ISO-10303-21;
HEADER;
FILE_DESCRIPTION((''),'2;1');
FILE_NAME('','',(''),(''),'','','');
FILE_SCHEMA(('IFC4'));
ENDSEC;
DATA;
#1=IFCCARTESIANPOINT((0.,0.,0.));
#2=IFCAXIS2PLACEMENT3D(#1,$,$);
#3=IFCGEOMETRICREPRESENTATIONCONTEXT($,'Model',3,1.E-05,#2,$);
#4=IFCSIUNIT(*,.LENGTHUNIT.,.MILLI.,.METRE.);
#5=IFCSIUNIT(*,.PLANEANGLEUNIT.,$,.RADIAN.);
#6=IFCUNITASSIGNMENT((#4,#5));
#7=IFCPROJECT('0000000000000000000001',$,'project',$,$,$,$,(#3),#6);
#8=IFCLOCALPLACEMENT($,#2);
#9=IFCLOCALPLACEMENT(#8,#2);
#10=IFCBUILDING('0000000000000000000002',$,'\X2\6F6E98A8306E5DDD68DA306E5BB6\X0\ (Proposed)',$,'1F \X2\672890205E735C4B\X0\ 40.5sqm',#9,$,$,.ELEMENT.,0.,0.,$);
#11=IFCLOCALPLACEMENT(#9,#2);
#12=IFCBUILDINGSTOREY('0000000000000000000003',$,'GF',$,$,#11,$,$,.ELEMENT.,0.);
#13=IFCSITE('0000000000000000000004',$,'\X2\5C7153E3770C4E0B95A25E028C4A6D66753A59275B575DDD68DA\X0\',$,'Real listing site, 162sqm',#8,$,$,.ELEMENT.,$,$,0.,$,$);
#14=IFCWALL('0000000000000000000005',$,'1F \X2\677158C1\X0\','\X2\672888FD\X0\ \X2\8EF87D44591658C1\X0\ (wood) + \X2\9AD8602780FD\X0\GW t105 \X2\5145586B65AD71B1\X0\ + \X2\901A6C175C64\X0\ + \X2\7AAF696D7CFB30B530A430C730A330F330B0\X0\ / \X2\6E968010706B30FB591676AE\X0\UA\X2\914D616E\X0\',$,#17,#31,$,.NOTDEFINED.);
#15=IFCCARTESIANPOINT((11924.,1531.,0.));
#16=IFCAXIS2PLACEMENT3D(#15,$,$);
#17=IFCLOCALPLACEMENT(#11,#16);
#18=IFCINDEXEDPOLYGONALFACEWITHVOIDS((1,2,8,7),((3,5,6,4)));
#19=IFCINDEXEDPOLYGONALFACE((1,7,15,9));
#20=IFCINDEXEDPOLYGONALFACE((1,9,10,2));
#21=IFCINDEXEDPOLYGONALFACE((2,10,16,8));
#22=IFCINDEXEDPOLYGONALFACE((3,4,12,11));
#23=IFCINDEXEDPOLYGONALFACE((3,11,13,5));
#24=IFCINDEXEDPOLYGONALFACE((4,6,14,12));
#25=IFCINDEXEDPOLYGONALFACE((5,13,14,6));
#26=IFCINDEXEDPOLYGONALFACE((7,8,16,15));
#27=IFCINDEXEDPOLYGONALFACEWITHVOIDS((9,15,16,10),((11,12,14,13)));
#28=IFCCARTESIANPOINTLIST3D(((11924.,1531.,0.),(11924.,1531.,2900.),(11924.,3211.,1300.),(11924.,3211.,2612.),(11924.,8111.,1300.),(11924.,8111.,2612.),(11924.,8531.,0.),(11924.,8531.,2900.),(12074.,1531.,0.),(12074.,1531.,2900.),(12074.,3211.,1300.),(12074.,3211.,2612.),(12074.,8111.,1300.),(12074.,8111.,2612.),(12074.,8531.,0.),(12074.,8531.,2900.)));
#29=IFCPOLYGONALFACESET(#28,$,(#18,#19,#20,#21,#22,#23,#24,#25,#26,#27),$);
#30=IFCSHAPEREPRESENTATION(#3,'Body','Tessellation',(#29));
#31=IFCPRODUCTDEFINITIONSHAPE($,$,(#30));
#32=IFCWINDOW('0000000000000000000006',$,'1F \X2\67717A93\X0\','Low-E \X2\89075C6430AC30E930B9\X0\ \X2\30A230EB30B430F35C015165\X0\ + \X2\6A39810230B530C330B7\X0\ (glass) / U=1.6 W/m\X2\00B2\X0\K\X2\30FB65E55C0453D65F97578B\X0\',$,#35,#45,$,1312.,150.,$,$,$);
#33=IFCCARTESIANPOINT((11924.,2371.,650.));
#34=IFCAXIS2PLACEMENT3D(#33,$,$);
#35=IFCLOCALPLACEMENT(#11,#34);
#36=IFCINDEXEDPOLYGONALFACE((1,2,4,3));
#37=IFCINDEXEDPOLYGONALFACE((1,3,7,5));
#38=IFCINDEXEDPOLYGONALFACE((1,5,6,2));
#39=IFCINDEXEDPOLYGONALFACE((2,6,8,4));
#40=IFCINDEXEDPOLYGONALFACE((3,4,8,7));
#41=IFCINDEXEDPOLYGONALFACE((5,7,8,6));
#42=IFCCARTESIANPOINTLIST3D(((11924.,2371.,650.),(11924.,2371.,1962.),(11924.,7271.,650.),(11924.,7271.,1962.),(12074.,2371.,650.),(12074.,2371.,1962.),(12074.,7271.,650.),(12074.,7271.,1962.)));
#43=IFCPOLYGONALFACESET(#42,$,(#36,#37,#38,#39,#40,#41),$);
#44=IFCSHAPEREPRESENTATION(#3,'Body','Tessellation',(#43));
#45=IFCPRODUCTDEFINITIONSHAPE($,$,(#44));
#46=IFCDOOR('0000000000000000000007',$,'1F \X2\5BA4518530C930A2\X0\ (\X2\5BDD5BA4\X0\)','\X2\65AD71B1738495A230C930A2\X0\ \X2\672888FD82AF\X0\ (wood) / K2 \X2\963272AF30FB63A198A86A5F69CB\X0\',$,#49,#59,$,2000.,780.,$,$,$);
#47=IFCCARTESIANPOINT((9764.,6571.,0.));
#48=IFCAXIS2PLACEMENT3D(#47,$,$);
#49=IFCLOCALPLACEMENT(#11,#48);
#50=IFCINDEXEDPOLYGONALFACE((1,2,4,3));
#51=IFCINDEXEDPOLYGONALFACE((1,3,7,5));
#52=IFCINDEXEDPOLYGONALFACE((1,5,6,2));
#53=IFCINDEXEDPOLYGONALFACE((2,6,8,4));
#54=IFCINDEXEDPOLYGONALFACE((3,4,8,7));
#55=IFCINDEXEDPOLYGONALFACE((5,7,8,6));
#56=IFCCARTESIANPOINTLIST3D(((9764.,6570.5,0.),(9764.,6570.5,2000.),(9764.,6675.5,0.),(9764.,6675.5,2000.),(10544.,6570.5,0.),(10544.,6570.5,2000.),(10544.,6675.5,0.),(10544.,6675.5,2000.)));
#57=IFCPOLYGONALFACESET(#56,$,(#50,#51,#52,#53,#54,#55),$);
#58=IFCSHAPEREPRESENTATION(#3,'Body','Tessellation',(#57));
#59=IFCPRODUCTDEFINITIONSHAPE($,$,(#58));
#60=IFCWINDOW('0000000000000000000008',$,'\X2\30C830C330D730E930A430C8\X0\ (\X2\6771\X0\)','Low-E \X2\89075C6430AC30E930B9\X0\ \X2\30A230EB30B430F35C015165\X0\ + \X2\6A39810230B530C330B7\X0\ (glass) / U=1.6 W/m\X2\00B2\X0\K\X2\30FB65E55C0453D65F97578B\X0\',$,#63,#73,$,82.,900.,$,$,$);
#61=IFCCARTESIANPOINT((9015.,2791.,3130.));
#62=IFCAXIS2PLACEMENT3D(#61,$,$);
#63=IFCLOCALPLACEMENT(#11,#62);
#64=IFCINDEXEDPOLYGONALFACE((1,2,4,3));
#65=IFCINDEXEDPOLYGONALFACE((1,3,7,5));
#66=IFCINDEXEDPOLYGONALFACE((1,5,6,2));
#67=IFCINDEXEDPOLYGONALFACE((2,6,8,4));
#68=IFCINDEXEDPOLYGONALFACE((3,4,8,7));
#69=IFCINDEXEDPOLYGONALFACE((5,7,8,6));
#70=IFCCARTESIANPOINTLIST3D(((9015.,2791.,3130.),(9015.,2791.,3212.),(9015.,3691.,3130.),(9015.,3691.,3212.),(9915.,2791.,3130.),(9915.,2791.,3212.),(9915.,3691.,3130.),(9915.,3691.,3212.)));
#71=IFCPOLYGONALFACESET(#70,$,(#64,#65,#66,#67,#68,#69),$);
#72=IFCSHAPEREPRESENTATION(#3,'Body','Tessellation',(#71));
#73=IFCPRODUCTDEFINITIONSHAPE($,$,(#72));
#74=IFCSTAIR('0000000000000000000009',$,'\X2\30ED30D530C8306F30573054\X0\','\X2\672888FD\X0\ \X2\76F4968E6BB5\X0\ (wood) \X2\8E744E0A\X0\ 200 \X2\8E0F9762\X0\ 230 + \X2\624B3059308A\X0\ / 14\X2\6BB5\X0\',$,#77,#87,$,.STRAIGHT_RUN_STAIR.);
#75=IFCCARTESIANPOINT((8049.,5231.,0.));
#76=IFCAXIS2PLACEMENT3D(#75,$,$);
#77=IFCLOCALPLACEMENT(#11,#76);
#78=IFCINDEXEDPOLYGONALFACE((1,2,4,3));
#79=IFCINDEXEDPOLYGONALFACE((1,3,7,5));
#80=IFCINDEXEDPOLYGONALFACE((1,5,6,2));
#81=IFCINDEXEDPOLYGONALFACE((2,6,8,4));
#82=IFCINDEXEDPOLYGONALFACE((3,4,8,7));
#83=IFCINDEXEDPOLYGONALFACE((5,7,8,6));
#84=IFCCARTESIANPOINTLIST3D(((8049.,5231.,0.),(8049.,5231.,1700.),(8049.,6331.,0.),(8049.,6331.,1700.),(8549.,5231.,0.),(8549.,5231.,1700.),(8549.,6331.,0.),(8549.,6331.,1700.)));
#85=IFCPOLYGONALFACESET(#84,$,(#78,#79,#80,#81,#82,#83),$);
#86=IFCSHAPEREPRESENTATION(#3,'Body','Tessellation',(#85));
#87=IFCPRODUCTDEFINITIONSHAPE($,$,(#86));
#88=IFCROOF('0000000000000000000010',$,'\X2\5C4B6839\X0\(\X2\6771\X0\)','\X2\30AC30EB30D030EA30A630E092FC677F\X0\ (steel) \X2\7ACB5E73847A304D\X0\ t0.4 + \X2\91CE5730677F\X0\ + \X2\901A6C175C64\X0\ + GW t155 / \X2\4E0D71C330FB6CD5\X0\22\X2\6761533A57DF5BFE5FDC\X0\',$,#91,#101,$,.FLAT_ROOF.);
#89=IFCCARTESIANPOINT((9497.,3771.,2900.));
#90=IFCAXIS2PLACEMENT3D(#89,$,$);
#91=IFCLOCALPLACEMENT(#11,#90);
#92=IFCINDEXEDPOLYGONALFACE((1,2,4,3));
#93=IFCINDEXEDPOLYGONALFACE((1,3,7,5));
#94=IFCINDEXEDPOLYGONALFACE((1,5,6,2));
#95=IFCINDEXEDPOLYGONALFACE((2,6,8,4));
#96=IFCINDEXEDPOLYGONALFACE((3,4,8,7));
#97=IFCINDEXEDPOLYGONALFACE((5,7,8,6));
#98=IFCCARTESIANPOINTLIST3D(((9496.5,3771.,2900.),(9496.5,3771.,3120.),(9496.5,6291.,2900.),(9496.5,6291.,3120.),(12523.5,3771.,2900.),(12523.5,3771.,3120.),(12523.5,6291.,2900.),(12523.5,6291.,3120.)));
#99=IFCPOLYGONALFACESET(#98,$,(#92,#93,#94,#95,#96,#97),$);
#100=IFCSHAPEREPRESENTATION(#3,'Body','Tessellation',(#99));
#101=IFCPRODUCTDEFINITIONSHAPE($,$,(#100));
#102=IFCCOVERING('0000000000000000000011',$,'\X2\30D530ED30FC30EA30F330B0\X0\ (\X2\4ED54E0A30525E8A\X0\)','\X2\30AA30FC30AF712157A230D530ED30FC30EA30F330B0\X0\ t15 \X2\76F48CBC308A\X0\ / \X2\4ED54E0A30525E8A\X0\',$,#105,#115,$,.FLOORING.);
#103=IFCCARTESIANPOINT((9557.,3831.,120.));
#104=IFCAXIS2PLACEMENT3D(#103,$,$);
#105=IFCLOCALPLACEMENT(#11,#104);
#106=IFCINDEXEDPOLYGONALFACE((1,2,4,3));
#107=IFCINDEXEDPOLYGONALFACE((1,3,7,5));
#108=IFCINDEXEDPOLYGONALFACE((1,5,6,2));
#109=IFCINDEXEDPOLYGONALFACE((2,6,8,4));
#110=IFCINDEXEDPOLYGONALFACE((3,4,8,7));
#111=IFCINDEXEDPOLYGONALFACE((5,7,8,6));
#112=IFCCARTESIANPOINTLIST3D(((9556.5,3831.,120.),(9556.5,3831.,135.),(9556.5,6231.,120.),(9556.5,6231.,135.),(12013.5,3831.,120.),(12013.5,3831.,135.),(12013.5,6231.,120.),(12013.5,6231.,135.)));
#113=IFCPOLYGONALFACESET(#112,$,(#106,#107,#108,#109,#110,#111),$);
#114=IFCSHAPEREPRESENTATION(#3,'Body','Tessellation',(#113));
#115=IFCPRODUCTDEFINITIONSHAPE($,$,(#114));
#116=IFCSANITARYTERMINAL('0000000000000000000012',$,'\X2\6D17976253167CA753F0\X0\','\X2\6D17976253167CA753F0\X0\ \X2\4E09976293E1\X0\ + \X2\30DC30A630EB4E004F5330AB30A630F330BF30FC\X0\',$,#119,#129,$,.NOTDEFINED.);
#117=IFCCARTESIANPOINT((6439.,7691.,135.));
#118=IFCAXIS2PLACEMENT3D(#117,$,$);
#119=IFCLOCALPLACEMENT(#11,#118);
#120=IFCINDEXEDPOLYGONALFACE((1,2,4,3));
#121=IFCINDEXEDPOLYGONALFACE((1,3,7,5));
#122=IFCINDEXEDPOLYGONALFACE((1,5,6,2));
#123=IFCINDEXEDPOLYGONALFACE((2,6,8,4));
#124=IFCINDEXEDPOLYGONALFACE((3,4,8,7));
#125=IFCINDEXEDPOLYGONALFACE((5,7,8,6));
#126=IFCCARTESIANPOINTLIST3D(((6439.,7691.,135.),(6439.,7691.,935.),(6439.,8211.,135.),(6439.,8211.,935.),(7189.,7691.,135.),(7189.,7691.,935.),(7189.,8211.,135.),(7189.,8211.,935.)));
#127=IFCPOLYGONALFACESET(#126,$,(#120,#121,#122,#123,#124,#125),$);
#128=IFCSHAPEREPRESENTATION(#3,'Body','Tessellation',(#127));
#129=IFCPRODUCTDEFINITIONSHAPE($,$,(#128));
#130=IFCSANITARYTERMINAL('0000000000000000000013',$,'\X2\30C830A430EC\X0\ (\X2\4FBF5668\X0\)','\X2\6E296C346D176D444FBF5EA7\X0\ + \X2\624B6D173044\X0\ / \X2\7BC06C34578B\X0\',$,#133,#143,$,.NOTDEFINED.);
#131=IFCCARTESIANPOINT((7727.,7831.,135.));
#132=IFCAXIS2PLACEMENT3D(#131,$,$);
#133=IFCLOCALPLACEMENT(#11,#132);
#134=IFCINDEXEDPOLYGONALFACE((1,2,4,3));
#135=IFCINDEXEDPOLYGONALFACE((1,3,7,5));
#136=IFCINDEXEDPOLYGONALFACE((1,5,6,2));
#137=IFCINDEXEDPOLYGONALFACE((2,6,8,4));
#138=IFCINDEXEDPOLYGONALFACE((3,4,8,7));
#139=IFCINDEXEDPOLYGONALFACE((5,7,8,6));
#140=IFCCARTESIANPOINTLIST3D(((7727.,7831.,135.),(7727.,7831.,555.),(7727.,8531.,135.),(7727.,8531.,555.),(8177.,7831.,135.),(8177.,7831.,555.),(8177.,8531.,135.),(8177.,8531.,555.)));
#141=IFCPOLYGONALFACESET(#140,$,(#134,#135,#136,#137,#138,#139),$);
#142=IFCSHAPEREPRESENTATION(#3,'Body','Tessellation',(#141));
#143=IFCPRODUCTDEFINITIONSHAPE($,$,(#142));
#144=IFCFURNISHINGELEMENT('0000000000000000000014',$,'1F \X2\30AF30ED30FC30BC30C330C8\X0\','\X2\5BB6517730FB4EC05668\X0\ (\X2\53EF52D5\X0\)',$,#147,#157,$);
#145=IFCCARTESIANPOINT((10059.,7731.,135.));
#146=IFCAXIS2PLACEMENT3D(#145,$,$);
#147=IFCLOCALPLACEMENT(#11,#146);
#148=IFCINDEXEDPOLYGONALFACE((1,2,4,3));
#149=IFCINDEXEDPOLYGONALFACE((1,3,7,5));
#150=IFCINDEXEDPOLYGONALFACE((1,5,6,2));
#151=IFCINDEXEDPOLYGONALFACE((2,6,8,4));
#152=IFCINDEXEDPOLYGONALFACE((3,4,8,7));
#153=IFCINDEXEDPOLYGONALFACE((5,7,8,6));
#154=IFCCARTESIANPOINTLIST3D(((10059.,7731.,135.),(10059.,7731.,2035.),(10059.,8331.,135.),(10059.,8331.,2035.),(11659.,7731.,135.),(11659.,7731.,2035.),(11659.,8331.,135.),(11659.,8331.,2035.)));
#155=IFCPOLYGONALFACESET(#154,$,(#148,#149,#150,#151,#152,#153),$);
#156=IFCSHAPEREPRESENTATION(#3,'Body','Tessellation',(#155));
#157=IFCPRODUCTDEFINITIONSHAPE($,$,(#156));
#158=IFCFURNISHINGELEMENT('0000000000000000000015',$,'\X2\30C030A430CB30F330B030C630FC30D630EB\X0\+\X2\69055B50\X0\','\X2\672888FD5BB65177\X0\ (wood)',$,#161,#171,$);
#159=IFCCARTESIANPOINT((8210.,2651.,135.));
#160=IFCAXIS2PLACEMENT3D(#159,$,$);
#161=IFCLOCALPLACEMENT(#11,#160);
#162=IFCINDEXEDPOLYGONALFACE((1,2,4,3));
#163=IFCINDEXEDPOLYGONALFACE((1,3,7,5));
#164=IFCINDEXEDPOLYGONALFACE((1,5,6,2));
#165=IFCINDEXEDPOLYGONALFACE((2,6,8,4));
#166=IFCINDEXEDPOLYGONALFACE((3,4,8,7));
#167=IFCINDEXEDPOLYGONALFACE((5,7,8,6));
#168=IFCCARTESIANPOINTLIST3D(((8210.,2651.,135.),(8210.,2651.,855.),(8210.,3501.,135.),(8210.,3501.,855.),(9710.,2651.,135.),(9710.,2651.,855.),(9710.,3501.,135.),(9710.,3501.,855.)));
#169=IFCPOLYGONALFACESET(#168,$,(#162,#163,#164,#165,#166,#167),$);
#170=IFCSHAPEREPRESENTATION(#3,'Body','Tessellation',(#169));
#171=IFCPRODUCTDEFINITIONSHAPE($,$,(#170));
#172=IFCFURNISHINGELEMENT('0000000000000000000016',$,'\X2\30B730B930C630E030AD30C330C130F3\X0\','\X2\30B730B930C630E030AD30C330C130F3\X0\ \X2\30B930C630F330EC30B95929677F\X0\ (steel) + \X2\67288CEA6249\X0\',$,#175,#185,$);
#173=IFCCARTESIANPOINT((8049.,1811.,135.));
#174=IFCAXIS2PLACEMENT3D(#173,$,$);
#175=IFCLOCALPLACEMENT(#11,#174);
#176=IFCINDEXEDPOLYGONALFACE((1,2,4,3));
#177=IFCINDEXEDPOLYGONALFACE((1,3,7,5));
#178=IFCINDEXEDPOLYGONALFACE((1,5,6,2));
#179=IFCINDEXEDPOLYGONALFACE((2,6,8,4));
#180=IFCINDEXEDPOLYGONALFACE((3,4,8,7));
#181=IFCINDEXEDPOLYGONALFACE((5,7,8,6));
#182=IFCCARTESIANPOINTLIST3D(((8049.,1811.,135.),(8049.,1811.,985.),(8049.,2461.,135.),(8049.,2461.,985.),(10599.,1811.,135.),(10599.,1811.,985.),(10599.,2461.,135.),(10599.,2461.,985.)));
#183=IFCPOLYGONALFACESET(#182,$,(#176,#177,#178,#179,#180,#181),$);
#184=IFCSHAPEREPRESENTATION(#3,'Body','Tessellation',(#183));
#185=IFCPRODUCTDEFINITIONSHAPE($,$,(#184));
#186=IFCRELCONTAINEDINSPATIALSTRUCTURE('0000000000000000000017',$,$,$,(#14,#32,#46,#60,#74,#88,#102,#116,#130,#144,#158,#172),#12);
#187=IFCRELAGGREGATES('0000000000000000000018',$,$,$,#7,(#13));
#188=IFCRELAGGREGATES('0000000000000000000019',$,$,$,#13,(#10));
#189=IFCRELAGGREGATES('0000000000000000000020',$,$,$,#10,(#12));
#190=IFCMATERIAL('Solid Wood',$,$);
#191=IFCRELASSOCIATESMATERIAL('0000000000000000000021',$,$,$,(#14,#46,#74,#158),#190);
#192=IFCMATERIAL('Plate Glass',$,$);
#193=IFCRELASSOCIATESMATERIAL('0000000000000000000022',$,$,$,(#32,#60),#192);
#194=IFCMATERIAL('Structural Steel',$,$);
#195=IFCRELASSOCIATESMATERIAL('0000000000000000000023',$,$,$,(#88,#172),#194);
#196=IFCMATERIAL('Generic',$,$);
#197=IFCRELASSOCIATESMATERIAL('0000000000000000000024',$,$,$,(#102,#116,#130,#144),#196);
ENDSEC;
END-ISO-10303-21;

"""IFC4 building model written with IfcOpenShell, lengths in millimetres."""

from ifc_helpers import new_model, si_unit, frame, frame_2d, origin, place, context, project, spatial, rectangle, extrude, material, element, fill, save


model = new_model("IFC4")

# Units and contexts
model_context = context("Model", 3, precision=1e-05, world=origin())
ifc_project = project(units=[si_unit("LENGTHUNIT", "METRE", prefix="MILLI"), si_unit("PLANEANGLEUNIT", "RADIAN")], contexts=[model_context])

# Site, building, storey
site_placement = place(None, origin())
site = spatial("IfcSite", under=ifc_project, at=site_placement, Name="山口県下関市豊浦町大字川棚", ObjectType="Real listing site, 162sqm", CompositionType="ELEMENT", RefElevation=0.0)
building_placement = place(site_placement, origin())
building = spatial("IfcBuilding", under=site, at=building_placement, Name="潮風の川棚の家 (Proposed)", ObjectType="1F 木造平屋 40.5sqm", CompositionType="ELEMENT", ElevationOfRefHeight=0.0, ElevationOfTerrain=0.0)
storey_placement = place(building_placement, origin())
storey = spatial("IfcBuildingStorey", under=building, at=storey_placement, Name="GF", CompositionType="ELEMENT", Elevation=0.0)

# Shared definitions
ifc_material_1 = material(Name="Solid Wood")

# Wall, opening, window
wall_1_placement = place(storey_placement, frame((11924.0, 1531.0, 0.0)))
wall_1 = element("IfcWall", 1, at=wall_1_placement, inside=storey, material=ifc_material_1, Name="1F 東壁", Description="木製 軸組外壁 (wood) + 高性能GW t105 充填断熱 + 通気層 + 窯業系サイディング / 準耐火・外皮UA配慮", PredefinedType="NOTDEFINED", context=model_context, shape_type="SweptSolid", body=[
    extrude(rectangle(XDim=150.0, YDim=7000.0, at=frame_2d((75.0, 3500.0))), frame((11924.0, 1531.0, 0.0)), (0.0, 0.0, 1.0), 2900.0),
])
opening_1_placement = place(storey_placement, frame((11924.0, 2371.0, 650.0)))
opening_1 = element("IfcOpeningElement", 2, at=opening_1_placement, cuts=wall_1, PredefinedType="NOTDEFINED", context=model_context, shape_type="SweptSolid", body=[
    extrude(rectangle(XDim=150.0, YDim=4900.0, at=frame_2d((75.0, 2450.0))), frame((11924.0, 2371.0, 650.0)), (0.0, 0.0, 1.0), 1312.0),
])
ifc_material_2 = material(Name="Plate Glass")
window_1_placement = place(storey_placement, frame((11924.0, 2371.0, 650.0)))
window_1 = element("IfcWindow", 3, at=window_1_placement, inside=storey, material=ifc_material_2, Name="1F 東窓", Description="Low-E 複層ガラス アルゴン封入 + 樹脂サッシ (glass) / U=1.6 W/m²K・日射取得型", OverallHeight=1312.0, OverallWidth=150.0, context=model_context, shape_type="SweptSolid", body=[
    extrude(rectangle(XDim=150.0, YDim=4900.0, at=frame_2d((75.0, 2450.0))), frame((11924.0, 2371.0, 650.0)), (0.0, 0.0, 1.0), 1312.0),
])
fill(opening_1, window_1)

# Door
door_placement = place(storey_placement, frame((9764.0, 6571.0, 0.0)))
element("IfcDoor", 4, at=door_placement, inside=storey, material=ifc_material_1, Name="1F 室内ドア (寝室)", Description="断熱玄関ドア 木製芯 (wood) / K2 防犯・採風機構", OverallHeight=2000.0, OverallWidth=780.0, context=model_context, shape_type="SweptSolid", body=[
    extrude(rectangle(XDim=780.0, YDim=105.0, at=frame_2d((390.0, 52.0))), frame((9764.0, 6571.0, 0.0)), (0.0, 0.0, 1.0), 2000.0),
])

# Window
window_2_placement = place(storey_placement, frame((9015.0, 2791.0, 3130.0)))
element("IfcWindow", 5, at=window_2_placement, inside=storey, material=ifc_material_2, Name="トップライト (東)", Description="Low-E 複層ガラス アルゴン封入 + 樹脂サッシ (glass) / U=1.6 W/m²K・日射取得型", OverallHeight=82.0, OverallWidth=900.0, context=model_context, shape_type="SweptSolid", body=[
    extrude(rectangle(XDim=900.0, YDim=900.0, at=frame_2d((450.0, 450.0))), frame((9015.0, 2791.0, 3130.0)), (0.0, 0.0, 1.0), 82.0),
])

# Stair
stair_placement = place(storey_placement, frame((8049.0, 5231.0, 0.0)))
element("IfcStair", 6, at=stair_placement, inside=storey, material=ifc_material_1, Name="ロフトはしご", Description="木製 直階段 (wood) 蹴上 200 踏面 230 + 手すり / 14段", PredefinedType="STRAIGHT_RUN_STAIR", context=model_context, shape_type="SweptSolid", body=[
    extrude(rectangle(XDim=500.0, YDim=1100.0, at=frame_2d((250.0, 550.0))), frame((8049.0, 5231.0, 0.0)), (0.0, 0.0, 1.0), 1700.0),
])

# Roof
ifc_material_3 = material(Name="Structural Steel")
roof_placement = place(storey_placement, frame((9497.0, 3771.0, 2900.0)))
element("IfcRoof", 7, at=roof_placement, inside=storey, material=ifc_material_3, Name="屋根(東)", Description="ガルバリウム鋼板 (steel) 立平葺き t0.4 + 野地板 + 通気層 + GW t155 / 不燃・法22条区域対応", PredefinedType="FLAT_ROOF", context=model_context, shape_type="SweptSolid", body=[
    extrude(rectangle(XDim=3027.0, YDim=2520.0, at=frame_2d((1513.0, 1260.0))), frame((9497.0, 3771.0, 2900.0)), (0.0, 0.0, 1.0), 220.0),
])

# Covering
ifc_material_4 = material(Name="Generic")
covering_placement = place(storey_placement, frame((9557.0, 3831.0, 120.0)))
element("IfcCovering", 8, at=covering_placement, inside=storey, material=ifc_material_4, Name="フローリング (仕上げ床)", Description="オーク無垢フローリング t15 直貼り / 仕上げ床", PredefinedType="FLOORING", context=model_context, shape_type="SweptSolid", body=[
    extrude(rectangle(XDim=2457.0, YDim=2400.0, at=frame_2d((1228.0, 1200.0))), frame((9557.0, 3831.0, 120.0)), (0.0, 0.0, 1.0), 15.0),
])

# Sanitary terminals
sanitary_terminal_1_placement = place(storey_placement, frame((6439.0, 7691.0, 135.0)))
element("IfcSanitaryTerminal", 9, at=sanitary_terminal_1_placement, inside=storey, material=ifc_material_4, Name="洗面化粧台", Description="洗面化粧台 三面鏡 + ボウル一体カウンター", PredefinedType="NOTDEFINED", context=model_context, shape_type="SweptSolid", body=[
    extrude(rectangle(XDim=750.0, YDim=520.0, at=frame_2d((375.0, 260.0))), frame((6439.0, 7691.0, 135.0)), (0.0, 0.0, 1.0), 800.0),
])
sanitary_terminal_2_placement = place(storey_placement, frame((7727.0, 7831.0, 135.0)))
element("IfcSanitaryTerminal", 10, at=sanitary_terminal_2_placement, inside=storey, material=ifc_material_4, Name="トイレ (便器)", Description="温水洗浄便座 + 手洗い / 節水型", PredefinedType="NOTDEFINED", context=model_context, shape_type="SweptSolid", body=[
    extrude(rectangle(XDim=450.0, YDim=700.0, at=frame_2d((225.0, 350.0))), frame((7727.0, 7831.0, 135.0)), (0.0, 0.0, 1.0), 420.0),
])

# Furnishing elements
furnishing_1_placement = place(storey_placement, frame((10059.0, 7731.0, 135.0)))
element("IfcFurnishingElement", 11, at=furnishing_1_placement, inside=storey, material=ifc_material_4, Name="1F クローゼット", Description="家具・什器 (可動)", context=model_context, shape_type="SweptSolid", body=[
    extrude(rectangle(XDim=1600.0, YDim=600.0, at=frame_2d((800.0, 300.0))), frame((10059.0, 7731.0, 135.0)), (0.0, 0.0, 1.0), 1900.0),
])
furnishing_2_placement = place(storey_placement, frame((8210.0, 2651.0, 135.0)))
element("IfcFurnishingElement", 12, at=furnishing_2_placement, inside=storey, material=ifc_material_1, Name="ダイニングテーブル+椅子", Description="木製家具 (wood)", context=model_context, shape_type="SweptSolid", body=[
    extrude(rectangle(XDim=1500.0, YDim=850.0, at=frame_2d((750.0, 425.0))), frame((8210.0, 2651.0, 135.0)), (0.0, 0.0, 1.0), 720.0),
])
furnishing_3_placement = place(storey_placement, frame((8049.0, 1811.0, 135.0)))
element("IfcFurnishingElement", 13, at=furnishing_3_placement, inside=storey, material=ifc_material_3, Name="システムキッチン", Description="システムキッチン ステンレス天板 (steel) + 木質扉", context=model_context, shape_type="SweptSolid", body=[
    extrude(rectangle(XDim=2550.0, YDim=650.0, at=frame_2d((1275.0, 325.0))), frame((8049.0, 1811.0, 135.0)), (0.0, 0.0, 1.0), 850.0),
])

save(model, "model.ifc")
